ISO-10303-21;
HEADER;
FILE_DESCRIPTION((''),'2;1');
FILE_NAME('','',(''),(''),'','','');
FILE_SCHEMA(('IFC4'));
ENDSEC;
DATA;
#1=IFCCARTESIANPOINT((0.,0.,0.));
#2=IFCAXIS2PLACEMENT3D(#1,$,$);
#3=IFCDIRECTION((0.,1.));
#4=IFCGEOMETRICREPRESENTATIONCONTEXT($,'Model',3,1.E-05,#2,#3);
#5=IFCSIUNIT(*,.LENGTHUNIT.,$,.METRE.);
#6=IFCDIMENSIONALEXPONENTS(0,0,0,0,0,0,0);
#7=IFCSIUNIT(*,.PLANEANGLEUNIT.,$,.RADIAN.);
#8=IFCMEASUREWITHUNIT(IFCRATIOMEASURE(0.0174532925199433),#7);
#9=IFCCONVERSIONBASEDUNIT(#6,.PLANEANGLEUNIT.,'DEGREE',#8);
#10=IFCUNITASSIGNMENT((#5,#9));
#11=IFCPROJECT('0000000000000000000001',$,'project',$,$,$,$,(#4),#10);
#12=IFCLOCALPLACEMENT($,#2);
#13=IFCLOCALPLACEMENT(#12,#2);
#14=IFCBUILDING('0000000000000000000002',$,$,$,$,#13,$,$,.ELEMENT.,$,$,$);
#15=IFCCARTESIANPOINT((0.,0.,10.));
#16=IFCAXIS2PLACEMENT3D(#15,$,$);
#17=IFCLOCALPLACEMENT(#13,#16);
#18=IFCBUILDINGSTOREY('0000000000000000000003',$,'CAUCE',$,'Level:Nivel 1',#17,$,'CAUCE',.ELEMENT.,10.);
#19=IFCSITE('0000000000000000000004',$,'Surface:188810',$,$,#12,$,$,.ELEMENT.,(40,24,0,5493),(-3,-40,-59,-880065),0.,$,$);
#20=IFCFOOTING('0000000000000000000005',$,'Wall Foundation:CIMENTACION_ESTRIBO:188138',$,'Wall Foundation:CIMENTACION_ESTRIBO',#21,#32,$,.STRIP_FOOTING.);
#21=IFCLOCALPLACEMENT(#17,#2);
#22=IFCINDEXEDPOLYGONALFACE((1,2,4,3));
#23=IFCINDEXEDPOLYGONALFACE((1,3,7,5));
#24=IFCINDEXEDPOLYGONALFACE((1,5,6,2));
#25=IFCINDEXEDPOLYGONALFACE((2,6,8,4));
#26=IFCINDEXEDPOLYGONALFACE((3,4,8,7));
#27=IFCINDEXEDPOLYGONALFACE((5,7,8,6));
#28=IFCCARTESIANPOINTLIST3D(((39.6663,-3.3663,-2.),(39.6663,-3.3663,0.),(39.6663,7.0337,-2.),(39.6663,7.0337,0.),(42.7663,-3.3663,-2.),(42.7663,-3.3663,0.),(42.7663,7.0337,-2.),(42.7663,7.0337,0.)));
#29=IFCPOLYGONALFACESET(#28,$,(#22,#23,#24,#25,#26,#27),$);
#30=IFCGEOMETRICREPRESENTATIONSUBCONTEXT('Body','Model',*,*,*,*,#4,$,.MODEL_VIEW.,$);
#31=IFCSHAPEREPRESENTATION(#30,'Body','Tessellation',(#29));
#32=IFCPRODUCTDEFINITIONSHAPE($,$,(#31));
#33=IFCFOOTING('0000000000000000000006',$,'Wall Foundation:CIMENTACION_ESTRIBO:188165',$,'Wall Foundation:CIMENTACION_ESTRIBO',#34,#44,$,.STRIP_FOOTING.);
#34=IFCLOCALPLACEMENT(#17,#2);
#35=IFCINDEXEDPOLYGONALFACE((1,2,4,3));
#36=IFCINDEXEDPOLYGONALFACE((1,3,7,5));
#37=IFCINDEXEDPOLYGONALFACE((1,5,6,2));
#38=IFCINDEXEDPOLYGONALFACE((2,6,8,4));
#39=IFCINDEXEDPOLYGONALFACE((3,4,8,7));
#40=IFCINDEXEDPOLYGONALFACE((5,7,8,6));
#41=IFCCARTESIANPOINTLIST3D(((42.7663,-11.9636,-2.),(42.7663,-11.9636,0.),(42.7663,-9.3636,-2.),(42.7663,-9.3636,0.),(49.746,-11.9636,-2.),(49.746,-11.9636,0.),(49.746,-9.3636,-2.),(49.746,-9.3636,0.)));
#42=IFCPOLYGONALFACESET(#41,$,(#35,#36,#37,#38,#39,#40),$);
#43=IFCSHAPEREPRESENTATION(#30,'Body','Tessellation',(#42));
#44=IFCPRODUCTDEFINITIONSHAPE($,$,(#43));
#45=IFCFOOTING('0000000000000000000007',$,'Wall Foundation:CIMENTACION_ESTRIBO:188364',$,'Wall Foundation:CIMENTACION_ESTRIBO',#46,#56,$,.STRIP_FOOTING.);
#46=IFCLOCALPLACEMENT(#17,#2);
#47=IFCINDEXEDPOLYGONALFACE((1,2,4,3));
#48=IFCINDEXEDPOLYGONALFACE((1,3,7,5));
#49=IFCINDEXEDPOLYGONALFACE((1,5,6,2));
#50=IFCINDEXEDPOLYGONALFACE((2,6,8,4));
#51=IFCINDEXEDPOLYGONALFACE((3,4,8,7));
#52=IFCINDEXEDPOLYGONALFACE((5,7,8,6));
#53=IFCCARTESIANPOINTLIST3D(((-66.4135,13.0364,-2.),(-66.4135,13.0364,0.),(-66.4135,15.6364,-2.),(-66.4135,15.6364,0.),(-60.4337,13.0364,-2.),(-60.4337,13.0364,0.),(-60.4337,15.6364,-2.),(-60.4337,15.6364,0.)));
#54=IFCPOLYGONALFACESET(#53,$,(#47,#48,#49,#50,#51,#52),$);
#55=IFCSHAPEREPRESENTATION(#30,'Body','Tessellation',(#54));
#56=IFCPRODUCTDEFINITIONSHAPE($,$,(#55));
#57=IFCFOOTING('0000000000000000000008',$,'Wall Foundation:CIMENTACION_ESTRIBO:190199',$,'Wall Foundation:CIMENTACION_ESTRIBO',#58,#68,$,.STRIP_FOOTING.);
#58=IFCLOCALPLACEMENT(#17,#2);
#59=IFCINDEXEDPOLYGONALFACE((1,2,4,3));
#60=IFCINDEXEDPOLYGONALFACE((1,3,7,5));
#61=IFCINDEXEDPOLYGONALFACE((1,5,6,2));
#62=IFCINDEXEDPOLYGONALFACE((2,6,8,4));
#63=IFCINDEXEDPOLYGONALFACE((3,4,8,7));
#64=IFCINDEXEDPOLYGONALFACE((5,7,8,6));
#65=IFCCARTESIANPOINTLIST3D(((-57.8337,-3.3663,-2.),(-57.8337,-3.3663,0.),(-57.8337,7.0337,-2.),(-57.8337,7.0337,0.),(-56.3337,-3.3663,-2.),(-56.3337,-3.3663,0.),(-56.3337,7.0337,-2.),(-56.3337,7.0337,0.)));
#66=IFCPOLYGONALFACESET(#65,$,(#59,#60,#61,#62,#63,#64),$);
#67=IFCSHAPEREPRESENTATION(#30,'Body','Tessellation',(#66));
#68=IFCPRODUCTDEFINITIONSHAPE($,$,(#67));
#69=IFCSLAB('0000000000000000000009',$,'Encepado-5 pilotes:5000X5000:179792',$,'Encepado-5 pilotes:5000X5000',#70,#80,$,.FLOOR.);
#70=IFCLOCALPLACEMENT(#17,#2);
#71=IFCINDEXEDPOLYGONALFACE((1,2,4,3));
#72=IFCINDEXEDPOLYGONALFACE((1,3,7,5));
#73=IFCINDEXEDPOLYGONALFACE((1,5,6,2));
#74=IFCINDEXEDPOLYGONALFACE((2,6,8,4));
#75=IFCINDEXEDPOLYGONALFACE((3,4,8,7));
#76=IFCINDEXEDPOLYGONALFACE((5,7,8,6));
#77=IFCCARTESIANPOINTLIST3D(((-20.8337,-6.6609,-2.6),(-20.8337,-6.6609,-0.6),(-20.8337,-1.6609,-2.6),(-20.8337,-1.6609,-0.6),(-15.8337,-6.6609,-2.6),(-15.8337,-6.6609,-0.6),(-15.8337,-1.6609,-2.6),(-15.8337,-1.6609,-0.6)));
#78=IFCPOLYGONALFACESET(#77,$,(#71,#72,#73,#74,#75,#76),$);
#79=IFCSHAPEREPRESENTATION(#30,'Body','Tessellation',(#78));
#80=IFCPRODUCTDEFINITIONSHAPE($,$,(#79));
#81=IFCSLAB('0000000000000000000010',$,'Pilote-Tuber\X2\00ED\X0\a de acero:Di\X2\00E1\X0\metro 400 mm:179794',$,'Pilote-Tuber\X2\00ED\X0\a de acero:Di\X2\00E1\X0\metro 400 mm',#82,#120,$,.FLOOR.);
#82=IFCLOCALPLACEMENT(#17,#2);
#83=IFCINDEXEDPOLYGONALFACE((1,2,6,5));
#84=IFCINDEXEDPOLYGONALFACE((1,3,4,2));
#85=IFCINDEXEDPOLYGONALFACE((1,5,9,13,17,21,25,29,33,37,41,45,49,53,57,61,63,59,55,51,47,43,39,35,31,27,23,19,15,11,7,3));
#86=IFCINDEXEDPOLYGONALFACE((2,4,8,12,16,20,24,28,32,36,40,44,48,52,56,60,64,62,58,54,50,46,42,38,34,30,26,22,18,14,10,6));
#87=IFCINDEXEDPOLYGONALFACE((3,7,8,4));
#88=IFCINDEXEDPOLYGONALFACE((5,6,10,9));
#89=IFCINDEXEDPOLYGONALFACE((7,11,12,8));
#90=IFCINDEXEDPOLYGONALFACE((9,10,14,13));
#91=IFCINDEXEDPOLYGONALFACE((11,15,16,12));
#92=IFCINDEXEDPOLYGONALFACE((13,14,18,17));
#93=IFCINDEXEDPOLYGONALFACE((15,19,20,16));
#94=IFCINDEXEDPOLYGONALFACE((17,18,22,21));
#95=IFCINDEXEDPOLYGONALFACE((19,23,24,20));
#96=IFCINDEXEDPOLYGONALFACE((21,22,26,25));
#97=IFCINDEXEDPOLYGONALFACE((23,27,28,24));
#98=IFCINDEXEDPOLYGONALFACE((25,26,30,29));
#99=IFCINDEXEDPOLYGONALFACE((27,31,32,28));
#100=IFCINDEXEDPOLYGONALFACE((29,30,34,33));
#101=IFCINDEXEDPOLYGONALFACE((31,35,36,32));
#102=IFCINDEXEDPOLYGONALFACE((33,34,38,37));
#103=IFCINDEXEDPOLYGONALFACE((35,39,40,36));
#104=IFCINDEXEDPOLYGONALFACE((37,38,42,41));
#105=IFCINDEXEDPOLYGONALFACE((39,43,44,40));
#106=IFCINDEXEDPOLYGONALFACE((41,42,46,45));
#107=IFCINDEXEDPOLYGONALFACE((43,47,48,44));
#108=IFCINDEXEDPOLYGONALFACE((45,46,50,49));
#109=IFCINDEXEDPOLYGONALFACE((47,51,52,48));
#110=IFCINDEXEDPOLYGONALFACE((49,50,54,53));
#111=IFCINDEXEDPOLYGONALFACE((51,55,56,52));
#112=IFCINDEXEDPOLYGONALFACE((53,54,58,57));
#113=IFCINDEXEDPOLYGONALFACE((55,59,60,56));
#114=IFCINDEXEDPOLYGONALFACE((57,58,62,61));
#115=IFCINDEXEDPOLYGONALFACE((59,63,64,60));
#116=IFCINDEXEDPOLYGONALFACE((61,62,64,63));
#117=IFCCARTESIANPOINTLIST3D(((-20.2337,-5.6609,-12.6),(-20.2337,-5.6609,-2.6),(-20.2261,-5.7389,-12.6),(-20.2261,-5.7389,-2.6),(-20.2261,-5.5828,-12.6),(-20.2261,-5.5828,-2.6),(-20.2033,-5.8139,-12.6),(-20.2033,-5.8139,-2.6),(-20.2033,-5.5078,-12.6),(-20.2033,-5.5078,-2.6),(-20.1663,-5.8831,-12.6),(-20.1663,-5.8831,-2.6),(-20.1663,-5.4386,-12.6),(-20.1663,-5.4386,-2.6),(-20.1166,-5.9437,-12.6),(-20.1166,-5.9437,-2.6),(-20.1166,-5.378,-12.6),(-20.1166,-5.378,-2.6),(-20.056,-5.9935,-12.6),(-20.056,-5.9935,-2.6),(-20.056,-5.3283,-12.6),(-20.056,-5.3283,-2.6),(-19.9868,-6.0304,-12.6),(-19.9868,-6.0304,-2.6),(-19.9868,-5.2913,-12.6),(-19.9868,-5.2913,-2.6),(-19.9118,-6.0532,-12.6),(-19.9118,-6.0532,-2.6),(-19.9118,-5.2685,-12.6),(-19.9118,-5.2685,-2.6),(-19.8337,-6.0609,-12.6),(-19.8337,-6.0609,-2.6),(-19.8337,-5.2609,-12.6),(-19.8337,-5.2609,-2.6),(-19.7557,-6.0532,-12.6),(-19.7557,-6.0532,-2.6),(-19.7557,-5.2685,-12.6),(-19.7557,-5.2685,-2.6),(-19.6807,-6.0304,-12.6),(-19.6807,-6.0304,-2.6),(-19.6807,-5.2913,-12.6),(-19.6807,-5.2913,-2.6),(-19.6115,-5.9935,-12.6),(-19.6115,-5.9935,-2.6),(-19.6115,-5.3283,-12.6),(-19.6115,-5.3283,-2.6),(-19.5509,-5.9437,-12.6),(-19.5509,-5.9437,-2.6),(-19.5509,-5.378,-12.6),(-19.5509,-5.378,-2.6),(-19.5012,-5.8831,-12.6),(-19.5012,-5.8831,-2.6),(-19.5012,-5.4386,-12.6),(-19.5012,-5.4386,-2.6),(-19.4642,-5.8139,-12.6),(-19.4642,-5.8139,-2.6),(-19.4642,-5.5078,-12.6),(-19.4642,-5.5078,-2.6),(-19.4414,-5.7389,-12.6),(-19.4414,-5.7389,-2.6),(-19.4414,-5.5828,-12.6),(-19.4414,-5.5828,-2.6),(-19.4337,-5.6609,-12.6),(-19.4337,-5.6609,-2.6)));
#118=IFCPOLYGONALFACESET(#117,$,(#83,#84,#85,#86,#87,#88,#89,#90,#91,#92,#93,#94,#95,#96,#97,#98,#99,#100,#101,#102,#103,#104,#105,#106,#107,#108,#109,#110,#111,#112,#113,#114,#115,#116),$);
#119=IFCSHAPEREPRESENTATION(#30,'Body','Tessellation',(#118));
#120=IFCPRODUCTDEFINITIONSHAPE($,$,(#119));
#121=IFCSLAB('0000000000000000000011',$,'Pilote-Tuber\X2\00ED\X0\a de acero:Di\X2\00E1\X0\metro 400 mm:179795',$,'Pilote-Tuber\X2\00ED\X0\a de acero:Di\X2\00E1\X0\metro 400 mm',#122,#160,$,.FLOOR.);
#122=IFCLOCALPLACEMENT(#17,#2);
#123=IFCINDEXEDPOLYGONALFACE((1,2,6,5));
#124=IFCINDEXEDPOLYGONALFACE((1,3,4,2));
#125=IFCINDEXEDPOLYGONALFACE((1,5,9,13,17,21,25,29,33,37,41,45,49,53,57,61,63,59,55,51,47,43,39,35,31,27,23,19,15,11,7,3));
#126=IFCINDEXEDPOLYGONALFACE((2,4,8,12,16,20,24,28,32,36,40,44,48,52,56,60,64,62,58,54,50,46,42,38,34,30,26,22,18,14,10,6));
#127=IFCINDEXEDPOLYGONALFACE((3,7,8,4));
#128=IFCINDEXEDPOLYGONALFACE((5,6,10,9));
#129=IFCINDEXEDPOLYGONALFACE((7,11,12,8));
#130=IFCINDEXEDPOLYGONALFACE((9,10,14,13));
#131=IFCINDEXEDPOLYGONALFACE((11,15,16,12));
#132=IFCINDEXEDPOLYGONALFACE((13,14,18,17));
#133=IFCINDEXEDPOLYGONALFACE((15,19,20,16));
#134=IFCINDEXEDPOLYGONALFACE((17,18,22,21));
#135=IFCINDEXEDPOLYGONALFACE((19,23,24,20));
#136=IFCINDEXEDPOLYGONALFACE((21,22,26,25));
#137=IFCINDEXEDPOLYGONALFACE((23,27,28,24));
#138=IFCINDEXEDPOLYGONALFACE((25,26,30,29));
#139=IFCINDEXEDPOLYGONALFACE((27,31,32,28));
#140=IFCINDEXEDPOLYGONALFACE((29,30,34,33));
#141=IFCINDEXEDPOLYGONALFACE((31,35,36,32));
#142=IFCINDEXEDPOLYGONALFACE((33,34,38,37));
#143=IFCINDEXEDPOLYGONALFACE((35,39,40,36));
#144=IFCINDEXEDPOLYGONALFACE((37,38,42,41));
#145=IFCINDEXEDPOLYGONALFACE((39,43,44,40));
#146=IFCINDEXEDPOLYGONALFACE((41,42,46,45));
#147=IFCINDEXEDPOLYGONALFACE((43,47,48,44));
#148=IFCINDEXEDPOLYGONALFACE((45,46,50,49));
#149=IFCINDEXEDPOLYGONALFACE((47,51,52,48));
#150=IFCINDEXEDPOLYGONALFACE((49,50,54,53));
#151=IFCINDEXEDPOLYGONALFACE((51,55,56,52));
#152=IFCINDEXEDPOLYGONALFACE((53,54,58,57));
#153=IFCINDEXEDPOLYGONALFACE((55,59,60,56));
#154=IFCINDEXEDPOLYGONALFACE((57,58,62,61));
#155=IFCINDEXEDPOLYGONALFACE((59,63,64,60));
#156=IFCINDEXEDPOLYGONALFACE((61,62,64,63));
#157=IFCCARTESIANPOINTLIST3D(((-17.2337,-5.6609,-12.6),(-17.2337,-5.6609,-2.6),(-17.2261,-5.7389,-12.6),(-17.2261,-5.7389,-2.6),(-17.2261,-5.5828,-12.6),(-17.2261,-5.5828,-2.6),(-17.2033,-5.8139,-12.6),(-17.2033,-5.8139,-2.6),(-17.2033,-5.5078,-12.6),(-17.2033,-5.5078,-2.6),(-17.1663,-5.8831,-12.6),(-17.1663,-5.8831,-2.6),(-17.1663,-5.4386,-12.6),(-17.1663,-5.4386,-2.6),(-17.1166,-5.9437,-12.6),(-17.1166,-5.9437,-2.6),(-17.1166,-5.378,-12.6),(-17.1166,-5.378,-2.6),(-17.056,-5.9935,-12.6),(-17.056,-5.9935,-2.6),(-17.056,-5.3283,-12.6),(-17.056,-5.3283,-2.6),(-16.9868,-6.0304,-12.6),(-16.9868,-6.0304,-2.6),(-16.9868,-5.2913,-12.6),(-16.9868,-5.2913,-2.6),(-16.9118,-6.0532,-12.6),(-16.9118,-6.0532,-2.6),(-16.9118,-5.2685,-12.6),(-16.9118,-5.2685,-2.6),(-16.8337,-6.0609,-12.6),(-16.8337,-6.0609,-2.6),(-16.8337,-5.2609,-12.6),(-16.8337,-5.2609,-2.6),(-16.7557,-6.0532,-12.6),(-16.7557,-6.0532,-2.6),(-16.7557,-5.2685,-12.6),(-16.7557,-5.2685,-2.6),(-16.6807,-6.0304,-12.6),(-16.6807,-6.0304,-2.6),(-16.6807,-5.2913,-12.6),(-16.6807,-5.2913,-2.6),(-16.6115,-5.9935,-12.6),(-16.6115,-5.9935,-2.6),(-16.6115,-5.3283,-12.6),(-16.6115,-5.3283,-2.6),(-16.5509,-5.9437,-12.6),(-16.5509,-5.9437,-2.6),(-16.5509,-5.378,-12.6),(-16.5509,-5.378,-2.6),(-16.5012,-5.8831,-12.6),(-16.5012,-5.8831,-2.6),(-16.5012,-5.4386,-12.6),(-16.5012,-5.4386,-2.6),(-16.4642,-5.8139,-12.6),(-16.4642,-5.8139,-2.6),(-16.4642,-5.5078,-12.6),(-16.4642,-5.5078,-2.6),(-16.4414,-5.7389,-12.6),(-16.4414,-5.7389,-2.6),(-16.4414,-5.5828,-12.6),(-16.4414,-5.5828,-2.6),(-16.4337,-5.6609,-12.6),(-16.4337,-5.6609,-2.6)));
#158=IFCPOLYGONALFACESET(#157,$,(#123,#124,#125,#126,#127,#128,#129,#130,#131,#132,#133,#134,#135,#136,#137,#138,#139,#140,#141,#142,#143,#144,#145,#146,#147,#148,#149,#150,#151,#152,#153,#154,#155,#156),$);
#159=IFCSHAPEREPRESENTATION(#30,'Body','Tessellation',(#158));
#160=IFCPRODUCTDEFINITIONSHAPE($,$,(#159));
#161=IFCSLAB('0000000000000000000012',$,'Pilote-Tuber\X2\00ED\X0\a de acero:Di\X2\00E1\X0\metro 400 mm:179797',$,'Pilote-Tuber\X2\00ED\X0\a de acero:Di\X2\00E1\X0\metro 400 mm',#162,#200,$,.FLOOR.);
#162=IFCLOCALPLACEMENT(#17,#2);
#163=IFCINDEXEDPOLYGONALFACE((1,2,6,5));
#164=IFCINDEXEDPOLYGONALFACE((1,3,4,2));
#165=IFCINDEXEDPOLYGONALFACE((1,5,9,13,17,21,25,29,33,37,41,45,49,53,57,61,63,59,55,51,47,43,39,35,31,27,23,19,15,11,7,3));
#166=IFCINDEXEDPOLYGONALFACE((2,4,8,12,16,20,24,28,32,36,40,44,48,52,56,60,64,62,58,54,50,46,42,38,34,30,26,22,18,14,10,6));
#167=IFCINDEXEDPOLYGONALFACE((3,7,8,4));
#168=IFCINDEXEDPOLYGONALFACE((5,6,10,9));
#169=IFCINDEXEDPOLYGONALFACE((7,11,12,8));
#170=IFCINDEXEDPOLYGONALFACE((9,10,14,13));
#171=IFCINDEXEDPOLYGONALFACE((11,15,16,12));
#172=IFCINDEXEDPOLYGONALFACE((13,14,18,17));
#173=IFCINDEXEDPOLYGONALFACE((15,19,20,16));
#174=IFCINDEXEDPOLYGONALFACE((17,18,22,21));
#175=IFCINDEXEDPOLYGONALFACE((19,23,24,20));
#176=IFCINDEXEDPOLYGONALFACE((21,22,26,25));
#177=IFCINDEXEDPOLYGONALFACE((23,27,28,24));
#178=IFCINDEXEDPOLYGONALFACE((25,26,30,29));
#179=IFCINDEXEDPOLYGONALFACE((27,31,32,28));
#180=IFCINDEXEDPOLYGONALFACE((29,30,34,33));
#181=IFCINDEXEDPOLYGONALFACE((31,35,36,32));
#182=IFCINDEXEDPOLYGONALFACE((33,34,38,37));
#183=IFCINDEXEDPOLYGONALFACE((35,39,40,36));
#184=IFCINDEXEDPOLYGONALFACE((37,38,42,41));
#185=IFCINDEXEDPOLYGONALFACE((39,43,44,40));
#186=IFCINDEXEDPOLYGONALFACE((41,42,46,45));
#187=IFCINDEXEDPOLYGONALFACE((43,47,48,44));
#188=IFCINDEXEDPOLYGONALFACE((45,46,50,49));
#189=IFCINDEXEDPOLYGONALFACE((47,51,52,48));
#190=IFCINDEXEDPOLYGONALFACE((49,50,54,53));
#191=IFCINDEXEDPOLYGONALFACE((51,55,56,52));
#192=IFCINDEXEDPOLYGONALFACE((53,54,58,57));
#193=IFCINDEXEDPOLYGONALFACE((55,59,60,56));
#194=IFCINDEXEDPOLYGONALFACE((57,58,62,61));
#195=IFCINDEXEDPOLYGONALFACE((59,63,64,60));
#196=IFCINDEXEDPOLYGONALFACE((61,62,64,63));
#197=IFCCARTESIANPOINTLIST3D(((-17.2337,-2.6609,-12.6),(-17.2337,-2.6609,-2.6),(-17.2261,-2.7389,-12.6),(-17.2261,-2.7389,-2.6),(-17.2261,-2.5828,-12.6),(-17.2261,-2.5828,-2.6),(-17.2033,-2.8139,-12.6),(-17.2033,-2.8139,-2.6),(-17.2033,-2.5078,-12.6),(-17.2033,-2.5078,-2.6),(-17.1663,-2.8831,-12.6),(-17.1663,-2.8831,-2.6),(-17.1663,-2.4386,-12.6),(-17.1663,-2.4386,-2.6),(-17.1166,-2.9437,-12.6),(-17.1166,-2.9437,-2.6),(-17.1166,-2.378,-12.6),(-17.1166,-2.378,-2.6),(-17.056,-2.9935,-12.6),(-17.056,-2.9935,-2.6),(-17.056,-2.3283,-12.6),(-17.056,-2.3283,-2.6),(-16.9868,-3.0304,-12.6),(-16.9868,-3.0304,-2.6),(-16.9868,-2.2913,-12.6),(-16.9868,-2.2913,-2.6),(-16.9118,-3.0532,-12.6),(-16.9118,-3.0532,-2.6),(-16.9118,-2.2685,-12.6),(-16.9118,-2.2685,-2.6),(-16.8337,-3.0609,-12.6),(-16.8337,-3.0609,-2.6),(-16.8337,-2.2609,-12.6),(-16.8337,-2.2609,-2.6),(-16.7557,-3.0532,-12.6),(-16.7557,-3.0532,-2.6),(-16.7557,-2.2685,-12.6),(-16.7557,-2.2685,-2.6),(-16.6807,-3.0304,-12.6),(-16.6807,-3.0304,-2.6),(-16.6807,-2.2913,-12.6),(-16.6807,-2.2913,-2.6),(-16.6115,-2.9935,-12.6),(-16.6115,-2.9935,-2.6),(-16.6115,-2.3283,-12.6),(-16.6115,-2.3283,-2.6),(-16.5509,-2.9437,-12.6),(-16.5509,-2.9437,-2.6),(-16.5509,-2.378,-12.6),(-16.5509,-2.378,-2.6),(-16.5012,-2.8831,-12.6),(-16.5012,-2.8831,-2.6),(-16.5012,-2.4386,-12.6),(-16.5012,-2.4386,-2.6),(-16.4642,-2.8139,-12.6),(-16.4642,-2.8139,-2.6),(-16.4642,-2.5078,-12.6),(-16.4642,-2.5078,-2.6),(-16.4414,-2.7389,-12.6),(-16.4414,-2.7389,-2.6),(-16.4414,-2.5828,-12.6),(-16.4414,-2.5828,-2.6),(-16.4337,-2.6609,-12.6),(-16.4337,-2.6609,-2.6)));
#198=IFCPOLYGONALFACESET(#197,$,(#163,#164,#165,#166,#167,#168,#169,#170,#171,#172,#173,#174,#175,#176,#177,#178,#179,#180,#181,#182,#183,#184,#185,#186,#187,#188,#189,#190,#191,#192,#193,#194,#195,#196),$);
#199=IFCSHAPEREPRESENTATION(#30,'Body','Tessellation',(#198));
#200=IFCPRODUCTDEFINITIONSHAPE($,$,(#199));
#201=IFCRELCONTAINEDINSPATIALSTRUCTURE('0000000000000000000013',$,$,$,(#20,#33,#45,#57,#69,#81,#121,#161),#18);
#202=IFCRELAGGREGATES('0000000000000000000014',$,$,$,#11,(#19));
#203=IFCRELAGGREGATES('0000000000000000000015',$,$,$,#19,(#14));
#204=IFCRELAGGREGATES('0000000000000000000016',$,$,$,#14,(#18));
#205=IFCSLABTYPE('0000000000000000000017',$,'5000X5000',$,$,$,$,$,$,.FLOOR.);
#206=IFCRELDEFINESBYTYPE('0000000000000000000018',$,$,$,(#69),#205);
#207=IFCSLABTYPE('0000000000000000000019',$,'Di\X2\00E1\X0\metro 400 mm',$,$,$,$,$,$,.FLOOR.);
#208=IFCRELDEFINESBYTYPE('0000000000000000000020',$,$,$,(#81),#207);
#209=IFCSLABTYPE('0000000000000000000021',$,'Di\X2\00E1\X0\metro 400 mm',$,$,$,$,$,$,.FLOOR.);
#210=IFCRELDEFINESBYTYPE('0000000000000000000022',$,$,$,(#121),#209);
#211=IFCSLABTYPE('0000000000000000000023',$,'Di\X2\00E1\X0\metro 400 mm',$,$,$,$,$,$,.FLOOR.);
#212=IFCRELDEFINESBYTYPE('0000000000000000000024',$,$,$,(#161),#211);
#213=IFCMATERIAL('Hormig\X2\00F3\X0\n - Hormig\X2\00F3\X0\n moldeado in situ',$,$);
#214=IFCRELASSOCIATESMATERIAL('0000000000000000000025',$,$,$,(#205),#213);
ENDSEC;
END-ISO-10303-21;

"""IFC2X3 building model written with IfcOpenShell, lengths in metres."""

from ifc_helpers import new_model, entity, si_unit, converted_unit, direction, frame, frame_2d, origin, place, context, subcontext, project, spatial, rectangle, circle, extrude, material, type_object, element, save


model = new_model("IFC2X3")

# Units and contexts
model_context = context("Model", 3, precision=1e-05, world=origin(), true_north=direction((0.0, 1.0)))
body_context = subcontext(model_context, "Body", "Model", "MODEL_VIEW")
ifc_project = project(units=[si_unit("LENGTHUNIT", "METRE"), converted_unit("PLANEANGLEUNIT", "DEGREE", entity("IfcRatioMeasure", 0.0174532925199433), si_unit("PLANEANGLEUNIT", "RADIAN"), dimensions=[0, 0, 0, 0, 0, 0, 0])], contexts=[model_context])

# Site, building, storey
site_placement = place(None, origin())
site = spatial("IfcSite", under=ifc_project, at=site_placement, Name="Surface:188810", CompositionType="ELEMENT", RefLatitude=(40, 24, 0, 5493), RefLongitude=(-3, -40, -59, -880065), RefElevation=0.0)
building_placement = place(site_placement, origin())
building = spatial("IfcBuilding", under=site, at=building_placement, CompositionType="ELEMENT")
storey_placement = place(building_placement, frame((0.0, 0.0, 10.0)))
storey = spatial("IfcBuildingStorey", under=building, at=storey_placement, Name="CAUCE", ObjectType="Level:Nivel 1", LongName="CAUCE", CompositionType="ELEMENT", Elevation=10.0)

# Footings
footing_1_placement = place(storey_placement, origin())
element("IfcFooting", 1, at=footing_1_placement, inside=storey, Name="Wall Foundation:CIMENTACION_ESTRIBO:188138", ObjectType="Wall Foundation:CIMENTACION_ESTRIBO", PredefinedType="STRIP_FOOTING", context=body_context, shape_type="SweptSolid", body=[
    extrude(rectangle(XDim=10.4, YDim=3.1, at=frame_2d((0.0, 0.0), x_axis=(1.0, 0.0))), frame((41.2163, 1.8337, -2.0), z_axis=(0.0, 0.0, 1.0), x_axis=(0.0, -1.0, 0.0)), (0.0, 0.0, 1.0), 2.0),
])
footing_2_placement = place(storey_placement, origin())
element("IfcFooting", 2, at=footing_2_placement, inside=storey, Name="Wall Foundation:CIMENTACION_ESTRIBO:188165", ObjectType="Wall Foundation:CIMENTACION_ESTRIBO", PredefinedType="STRIP_FOOTING", context=body_context, shape_type="SweptSolid", body=[
    extrude(rectangle(XDim=6.9798, YDim=2.6, at=frame_2d((0.0, 0.0), x_axis=(1.0, 0.0))), frame((46.2561, -10.6636, -2.0), z_axis=(0.0, 0.0, 1.0), x_axis=(-1.0, 0.0, 0.0)), (0.0, 0.0, 1.0), 2.0),
])
footing_3_placement = place(storey_placement, origin())
element("IfcFooting", 3, at=footing_3_placement, inside=storey, Name="Wall Foundation:CIMENTACION_ESTRIBO:188364", ObjectType="Wall Foundation:CIMENTACION_ESTRIBO", PredefinedType="STRIP_FOOTING", context=body_context, shape_type="SweptSolid", body=[
    extrude(rectangle(XDim=5.9798, YDim=2.6, at=frame_2d((0.0, 0.0), x_axis=(1.0, 0.0))), frame((-63.4236, 14.3364, -2.0)), (0.0, 0.0, 1.0), 2.0),
])
footing_4_placement = place(storey_placement, origin())
element("IfcFooting", 4, at=footing_4_placement, inside=storey, Name="Wall Foundation:CIMENTACION_ESTRIBO:190199", ObjectType="Wall Foundation:CIMENTACION_ESTRIBO", PredefinedType="STRIP_FOOTING", context=body_context, shape_type="SweptSolid", body=[
    extrude(rectangle(XDim=1.5, YDim=10.4, at=frame_2d((0.0, 0.0), x_axis=(1.0, 0.0))), frame((-57.0837, 1.8337, -2.0), z_axis=(0.0, 0.0, 1.0), x_axis=(-1.0, 0.0, 0.0)), (0.0, 0.0, 1.0), 2.0),
])

# Slabs
ifc_material_1 = material(Name="Hormigón - Hormigón moldeado in situ")
slab_type_1 = type_object("IfcSlabType", Name="5000X5000", PredefinedType="FLOOR", material=ifc_material_1)
slab_1_placement = place(storey_placement, origin())
element("IfcSlab", 5, at=slab_1_placement, inside=storey, type_object=slab_type_1, Name="Encepado-5 pilotes:5000X5000:179792", ObjectType="Encepado-5 pilotes:5000X5000", PredefinedType="FLOOR", context=body_context, shape_type="SweptSolid", body=[
    extrude(rectangle(XDim=5.0, YDim=5.0, at=frame_2d((0.0, 0.0), x_axis=(1.0, 0.0))), frame((-18.3337, -4.1609, -2.6), z_axis=(0.0, 0.0, 1.0), x_axis=(-1.0, 0.0, 0.0)), (0.0, 0.0, 1.0), 2.0),
])
slab_type_2 = type_object("IfcSlabType", Name="Diámetro 400 mm", PredefinedType="FLOOR")
slab_2_placement = place(storey_placement, origin())
element("IfcSlab", 6, at=slab_2_placement, inside=storey, type_object=slab_type_2, Name="Pilote-Tubería de acero:Diámetro 400 mm:179794", ObjectType="Pilote-Tubería de acero:Diámetro 400 mm", PredefinedType="FLOOR", context=body_context, shape_type="SweptSolid", body=[
    extrude(circle(Radius=0.4, at=frame_2d((0.0, 0.0), x_axis=(1.0, 0.0))), frame((-19.8337, -5.6609, -12.6)), (0.0, 0.0, 1.0), 10.0),
])
slab_type_3 = type_object("IfcSlabType", Name="Diámetro 400 mm", PredefinedType="FLOOR")
slab_3_placement = place(storey_placement, origin())
element("IfcSlab", 7, at=slab_3_placement, inside=storey, type_object=slab_type_3, Name="Pilote-Tubería de acero:Diámetro 400 mm:179795", ObjectType="Pilote-Tubería de acero:Diámetro 400 mm", PredefinedType="FLOOR", context=body_context, shape_type="SweptSolid", body=[
    extrude(circle(Radius=0.4, at=frame_2d((0.0, 0.0), x_axis=(1.0, 0.0))), frame((-16.8337, -5.6609, -12.6)), (0.0, 0.0, 1.0), 10.0),
])
slab_type_4 = type_object("IfcSlabType", Name="Diámetro 400 mm", PredefinedType="FLOOR")
slab_4_placement = place(storey_placement, origin())
element("IfcSlab", 8, at=slab_4_placement, inside=storey, type_object=slab_type_4, Name="Pilote-Tubería de acero:Diámetro 400 mm:179797", ObjectType="Pilote-Tubería de acero:Diámetro 400 mm", PredefinedType="FLOOR", context=body_context, shape_type="SweptSolid", body=[
    extrude(circle(Radius=0.4, at=frame_2d((0.0, 0.0), x_axis=(1.0, 0.0))), frame((-16.8337, -2.6609, -12.6)), (0.0, 0.0, 1.0), 10.0),
])

save(model, "model.ifc")
